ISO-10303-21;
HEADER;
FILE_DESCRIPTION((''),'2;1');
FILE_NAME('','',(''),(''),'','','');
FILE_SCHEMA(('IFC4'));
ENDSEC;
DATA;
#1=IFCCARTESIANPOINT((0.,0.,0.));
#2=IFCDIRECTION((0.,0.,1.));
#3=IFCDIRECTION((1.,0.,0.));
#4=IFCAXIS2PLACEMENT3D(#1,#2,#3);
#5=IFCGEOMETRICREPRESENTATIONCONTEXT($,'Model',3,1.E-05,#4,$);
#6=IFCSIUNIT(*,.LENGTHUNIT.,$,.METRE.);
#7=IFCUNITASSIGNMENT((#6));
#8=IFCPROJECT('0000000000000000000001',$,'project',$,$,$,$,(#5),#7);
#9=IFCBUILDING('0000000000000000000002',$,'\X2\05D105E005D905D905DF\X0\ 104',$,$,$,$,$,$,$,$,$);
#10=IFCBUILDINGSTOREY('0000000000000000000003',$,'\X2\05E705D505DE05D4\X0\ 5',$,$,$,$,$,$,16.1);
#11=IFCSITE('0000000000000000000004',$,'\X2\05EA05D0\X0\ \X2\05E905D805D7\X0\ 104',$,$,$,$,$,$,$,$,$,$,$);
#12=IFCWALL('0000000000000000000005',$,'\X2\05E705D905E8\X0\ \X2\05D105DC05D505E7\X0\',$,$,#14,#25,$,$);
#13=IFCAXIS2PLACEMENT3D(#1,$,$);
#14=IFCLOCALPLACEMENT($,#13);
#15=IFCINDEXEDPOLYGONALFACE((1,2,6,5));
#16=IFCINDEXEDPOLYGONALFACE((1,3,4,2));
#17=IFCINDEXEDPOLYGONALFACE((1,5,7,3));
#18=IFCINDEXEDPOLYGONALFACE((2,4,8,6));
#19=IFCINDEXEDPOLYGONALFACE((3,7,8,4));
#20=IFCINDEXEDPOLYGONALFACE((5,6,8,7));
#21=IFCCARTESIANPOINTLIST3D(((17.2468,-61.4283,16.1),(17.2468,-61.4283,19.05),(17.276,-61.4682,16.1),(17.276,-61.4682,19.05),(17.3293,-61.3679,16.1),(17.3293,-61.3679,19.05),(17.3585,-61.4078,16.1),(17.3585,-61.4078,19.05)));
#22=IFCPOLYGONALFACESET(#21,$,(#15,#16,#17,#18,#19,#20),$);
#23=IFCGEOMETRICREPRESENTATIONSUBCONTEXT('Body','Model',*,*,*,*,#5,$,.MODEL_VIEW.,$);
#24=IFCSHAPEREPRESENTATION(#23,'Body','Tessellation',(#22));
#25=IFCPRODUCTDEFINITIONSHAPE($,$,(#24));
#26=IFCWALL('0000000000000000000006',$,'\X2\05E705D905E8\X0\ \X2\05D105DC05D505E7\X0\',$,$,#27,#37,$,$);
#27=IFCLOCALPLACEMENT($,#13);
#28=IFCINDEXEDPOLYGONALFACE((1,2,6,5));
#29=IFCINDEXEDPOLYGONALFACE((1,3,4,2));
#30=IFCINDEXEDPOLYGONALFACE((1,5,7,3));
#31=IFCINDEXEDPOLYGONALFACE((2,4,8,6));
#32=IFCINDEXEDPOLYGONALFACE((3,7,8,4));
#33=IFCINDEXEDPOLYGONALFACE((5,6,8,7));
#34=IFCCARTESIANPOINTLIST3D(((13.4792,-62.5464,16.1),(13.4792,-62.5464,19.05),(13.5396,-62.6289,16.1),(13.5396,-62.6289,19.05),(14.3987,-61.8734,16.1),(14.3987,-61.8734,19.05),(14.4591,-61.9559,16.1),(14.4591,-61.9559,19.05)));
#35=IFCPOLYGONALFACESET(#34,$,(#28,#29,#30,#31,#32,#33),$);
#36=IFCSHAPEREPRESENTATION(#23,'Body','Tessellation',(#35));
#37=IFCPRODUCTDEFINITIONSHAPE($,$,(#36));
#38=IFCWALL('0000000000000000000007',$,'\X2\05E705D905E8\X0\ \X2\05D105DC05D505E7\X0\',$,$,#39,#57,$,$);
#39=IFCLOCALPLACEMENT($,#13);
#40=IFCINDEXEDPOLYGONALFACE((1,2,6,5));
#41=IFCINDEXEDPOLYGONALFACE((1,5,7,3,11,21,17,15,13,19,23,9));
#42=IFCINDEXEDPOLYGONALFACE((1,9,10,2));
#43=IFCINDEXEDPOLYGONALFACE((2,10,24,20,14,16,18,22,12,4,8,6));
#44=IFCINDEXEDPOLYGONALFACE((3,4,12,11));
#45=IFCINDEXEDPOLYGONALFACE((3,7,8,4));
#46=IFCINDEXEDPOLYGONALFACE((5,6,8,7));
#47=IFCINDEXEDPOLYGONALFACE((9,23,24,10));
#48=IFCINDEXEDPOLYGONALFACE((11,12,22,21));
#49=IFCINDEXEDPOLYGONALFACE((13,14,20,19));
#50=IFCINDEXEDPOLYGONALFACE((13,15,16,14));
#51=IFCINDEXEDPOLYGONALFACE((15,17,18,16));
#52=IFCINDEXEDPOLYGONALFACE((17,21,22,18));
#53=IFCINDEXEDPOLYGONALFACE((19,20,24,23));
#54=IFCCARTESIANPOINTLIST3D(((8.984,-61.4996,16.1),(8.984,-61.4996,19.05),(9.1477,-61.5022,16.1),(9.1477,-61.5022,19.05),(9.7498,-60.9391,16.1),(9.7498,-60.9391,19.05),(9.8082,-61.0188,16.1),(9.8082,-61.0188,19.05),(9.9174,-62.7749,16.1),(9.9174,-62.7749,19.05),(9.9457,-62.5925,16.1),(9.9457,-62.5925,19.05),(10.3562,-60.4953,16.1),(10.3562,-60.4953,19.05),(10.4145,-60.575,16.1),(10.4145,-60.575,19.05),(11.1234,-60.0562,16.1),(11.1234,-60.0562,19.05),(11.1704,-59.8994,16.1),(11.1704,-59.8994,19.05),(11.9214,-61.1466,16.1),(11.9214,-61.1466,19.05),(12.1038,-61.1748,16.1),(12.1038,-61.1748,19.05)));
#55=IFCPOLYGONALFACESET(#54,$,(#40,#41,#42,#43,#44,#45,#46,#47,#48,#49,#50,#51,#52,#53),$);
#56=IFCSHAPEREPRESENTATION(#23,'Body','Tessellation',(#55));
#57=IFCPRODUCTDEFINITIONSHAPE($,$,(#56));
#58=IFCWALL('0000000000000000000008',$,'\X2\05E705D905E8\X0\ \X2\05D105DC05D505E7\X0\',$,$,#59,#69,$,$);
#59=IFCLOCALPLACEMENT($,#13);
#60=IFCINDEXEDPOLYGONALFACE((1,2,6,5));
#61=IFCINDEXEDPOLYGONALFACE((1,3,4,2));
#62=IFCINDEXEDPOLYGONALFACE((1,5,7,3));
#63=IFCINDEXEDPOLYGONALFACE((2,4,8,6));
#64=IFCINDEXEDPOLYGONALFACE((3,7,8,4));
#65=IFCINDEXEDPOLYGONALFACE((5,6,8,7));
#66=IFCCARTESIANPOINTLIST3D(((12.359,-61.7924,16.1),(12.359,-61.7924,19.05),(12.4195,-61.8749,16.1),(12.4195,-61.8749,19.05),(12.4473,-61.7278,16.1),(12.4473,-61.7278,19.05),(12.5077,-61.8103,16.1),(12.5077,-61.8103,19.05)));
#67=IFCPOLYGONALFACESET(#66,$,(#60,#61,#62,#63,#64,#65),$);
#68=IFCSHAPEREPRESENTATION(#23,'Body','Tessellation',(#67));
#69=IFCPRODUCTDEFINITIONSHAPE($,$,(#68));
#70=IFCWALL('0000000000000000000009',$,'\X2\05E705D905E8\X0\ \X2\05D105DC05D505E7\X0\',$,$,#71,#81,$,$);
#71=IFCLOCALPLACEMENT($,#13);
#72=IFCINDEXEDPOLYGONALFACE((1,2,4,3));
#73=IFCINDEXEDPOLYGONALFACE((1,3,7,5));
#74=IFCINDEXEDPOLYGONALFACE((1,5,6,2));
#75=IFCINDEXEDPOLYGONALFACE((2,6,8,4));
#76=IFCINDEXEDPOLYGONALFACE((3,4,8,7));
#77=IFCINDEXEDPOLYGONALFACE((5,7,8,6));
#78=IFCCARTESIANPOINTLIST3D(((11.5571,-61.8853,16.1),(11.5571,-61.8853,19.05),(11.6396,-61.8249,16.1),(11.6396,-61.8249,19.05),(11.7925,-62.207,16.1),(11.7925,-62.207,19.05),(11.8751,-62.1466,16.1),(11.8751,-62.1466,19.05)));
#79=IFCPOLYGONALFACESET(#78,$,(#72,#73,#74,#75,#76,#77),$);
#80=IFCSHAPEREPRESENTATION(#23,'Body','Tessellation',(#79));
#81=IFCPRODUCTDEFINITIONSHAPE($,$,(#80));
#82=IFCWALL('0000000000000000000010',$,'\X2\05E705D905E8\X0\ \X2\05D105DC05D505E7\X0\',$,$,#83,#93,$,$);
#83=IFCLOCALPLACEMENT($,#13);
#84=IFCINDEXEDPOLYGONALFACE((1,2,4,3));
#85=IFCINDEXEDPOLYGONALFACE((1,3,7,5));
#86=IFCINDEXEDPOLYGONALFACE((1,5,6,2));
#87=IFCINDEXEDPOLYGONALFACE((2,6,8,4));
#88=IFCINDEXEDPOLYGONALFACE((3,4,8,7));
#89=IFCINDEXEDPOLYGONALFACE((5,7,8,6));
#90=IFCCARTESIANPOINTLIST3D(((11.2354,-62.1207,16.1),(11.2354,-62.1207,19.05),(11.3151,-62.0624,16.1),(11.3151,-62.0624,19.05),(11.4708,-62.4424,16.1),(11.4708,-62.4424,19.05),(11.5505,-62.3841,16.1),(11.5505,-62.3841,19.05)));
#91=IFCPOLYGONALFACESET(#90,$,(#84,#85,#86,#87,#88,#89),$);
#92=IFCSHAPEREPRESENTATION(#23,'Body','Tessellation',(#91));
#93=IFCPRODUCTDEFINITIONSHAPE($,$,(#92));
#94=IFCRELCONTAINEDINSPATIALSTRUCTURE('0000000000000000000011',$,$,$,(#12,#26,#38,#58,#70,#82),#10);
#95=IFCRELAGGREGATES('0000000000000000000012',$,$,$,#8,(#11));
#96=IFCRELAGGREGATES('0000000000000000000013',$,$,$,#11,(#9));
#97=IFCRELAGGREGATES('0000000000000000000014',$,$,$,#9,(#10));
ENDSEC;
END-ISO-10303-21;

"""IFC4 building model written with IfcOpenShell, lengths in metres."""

from ifc_helpers import new_model, si_unit, frame, origin_with_axes, context, subcontext, project, spatial, polyline, outline, extrude, element, save


model = new_model("IFC4")

# Units and contexts
model_context = context("Model", 3, precision=1e-05, world=origin_with_axes())
body_context = subcontext(model_context, "Body", "Model", "MODEL_VIEW")
ifc_project = project(units=[si_unit("LENGTHUNIT", "METRE")], contexts=[model_context])

# Site, building, storey
site = spatial("IfcSite", under=ifc_project, Name="תא שטח 104")
building = spatial("IfcBuilding", under=site, Name="בניין 104")
storey = spatial("IfcBuildingStorey", under=building, Name="קומה 5", Elevation=16.1)

# Walls
element("IfcWall", 1, inside=storey, Name="קיר בלוק", context=body_context, shape_type="SweptSolid", body=[
    extrude(outline(polyline([(17.3585, -61.4078), (17.3293, -61.3679), (17.2468, -61.4283), (17.276, -61.4682), (17.3585, -61.4078)])), frame((0.0, 0.0, 16.1)), (0.0, 0.0, 1.0), 2.95),
])
element("IfcWall", 2, inside=storey, Name="קיר בלוק", context=body_context, shape_type="SweptSolid", body=[
    extrude(outline(polyline([(14.4591, -61.9559), (14.3987, -61.8734), (13.4792, -62.5464), (13.5396, -62.6289), (14.4591, -61.9559)])), frame((0.0, 0.0, 16.1)), (0.0, 0.0, 1.0), 2.95),
])
element("IfcWall", 3, inside=storey, Name="קיר בלוק", context=body_context, shape_type="SweptSolid", body=[
    extrude(outline(polyline([(11.1704, -59.8994), (10.3562, -60.4953), (10.4145, -60.575), (11.1234, -60.0562), (11.9214, -61.1466), (9.9457, -62.5925), (9.1477, -61.5022), (9.8082, -61.0188), (9.7498, -60.9391), (8.984, -61.4996), (9.9174, -62.7749), (12.1038, -61.1748), (11.1704, -59.8994)])), frame((0.0, 0.0, 16.1)), (0.0, 0.0, 1.0), 2.95),
])
element("IfcWall", 4, inside=storey, Name="קיר בלוק", context=body_context, shape_type="SweptSolid", body=[
    extrude(outline(polyline([(12.4473, -61.7278), (12.359, -61.7924), (12.4195, -61.8749), (12.5077, -61.8103), (12.4473, -61.7278)])), frame((0.0, 0.0, 16.1)), (0.0, 0.0, 1.0), 2.95),
])
element("IfcWall", 5, inside=storey, Name="קיר בלוק", context=body_context, shape_type="SweptSolid", body=[
    extrude(outline(polyline([(11.6396, -61.8249), (11.5571, -61.8853), (11.7925, -62.207), (11.8751, -62.1466), (11.6396, -61.8249)])), frame((0.0, 0.0, 16.1)), (0.0, 0.0, 1.0), 2.95),
])
element("IfcWall", 6, inside=storey, Name="קיר בלוק", context=body_context, shape_type="SweptSolid", body=[
    extrude(outline(polyline([(11.3151, -62.0624), (11.2354, -62.1207), (11.4708, -62.4424), (11.5505, -62.3841), (11.3151, -62.0624)])), frame((0.0, 0.0, 16.1)), (0.0, 0.0, 1.0), 2.95),
])

save(model, "model.ifc")
